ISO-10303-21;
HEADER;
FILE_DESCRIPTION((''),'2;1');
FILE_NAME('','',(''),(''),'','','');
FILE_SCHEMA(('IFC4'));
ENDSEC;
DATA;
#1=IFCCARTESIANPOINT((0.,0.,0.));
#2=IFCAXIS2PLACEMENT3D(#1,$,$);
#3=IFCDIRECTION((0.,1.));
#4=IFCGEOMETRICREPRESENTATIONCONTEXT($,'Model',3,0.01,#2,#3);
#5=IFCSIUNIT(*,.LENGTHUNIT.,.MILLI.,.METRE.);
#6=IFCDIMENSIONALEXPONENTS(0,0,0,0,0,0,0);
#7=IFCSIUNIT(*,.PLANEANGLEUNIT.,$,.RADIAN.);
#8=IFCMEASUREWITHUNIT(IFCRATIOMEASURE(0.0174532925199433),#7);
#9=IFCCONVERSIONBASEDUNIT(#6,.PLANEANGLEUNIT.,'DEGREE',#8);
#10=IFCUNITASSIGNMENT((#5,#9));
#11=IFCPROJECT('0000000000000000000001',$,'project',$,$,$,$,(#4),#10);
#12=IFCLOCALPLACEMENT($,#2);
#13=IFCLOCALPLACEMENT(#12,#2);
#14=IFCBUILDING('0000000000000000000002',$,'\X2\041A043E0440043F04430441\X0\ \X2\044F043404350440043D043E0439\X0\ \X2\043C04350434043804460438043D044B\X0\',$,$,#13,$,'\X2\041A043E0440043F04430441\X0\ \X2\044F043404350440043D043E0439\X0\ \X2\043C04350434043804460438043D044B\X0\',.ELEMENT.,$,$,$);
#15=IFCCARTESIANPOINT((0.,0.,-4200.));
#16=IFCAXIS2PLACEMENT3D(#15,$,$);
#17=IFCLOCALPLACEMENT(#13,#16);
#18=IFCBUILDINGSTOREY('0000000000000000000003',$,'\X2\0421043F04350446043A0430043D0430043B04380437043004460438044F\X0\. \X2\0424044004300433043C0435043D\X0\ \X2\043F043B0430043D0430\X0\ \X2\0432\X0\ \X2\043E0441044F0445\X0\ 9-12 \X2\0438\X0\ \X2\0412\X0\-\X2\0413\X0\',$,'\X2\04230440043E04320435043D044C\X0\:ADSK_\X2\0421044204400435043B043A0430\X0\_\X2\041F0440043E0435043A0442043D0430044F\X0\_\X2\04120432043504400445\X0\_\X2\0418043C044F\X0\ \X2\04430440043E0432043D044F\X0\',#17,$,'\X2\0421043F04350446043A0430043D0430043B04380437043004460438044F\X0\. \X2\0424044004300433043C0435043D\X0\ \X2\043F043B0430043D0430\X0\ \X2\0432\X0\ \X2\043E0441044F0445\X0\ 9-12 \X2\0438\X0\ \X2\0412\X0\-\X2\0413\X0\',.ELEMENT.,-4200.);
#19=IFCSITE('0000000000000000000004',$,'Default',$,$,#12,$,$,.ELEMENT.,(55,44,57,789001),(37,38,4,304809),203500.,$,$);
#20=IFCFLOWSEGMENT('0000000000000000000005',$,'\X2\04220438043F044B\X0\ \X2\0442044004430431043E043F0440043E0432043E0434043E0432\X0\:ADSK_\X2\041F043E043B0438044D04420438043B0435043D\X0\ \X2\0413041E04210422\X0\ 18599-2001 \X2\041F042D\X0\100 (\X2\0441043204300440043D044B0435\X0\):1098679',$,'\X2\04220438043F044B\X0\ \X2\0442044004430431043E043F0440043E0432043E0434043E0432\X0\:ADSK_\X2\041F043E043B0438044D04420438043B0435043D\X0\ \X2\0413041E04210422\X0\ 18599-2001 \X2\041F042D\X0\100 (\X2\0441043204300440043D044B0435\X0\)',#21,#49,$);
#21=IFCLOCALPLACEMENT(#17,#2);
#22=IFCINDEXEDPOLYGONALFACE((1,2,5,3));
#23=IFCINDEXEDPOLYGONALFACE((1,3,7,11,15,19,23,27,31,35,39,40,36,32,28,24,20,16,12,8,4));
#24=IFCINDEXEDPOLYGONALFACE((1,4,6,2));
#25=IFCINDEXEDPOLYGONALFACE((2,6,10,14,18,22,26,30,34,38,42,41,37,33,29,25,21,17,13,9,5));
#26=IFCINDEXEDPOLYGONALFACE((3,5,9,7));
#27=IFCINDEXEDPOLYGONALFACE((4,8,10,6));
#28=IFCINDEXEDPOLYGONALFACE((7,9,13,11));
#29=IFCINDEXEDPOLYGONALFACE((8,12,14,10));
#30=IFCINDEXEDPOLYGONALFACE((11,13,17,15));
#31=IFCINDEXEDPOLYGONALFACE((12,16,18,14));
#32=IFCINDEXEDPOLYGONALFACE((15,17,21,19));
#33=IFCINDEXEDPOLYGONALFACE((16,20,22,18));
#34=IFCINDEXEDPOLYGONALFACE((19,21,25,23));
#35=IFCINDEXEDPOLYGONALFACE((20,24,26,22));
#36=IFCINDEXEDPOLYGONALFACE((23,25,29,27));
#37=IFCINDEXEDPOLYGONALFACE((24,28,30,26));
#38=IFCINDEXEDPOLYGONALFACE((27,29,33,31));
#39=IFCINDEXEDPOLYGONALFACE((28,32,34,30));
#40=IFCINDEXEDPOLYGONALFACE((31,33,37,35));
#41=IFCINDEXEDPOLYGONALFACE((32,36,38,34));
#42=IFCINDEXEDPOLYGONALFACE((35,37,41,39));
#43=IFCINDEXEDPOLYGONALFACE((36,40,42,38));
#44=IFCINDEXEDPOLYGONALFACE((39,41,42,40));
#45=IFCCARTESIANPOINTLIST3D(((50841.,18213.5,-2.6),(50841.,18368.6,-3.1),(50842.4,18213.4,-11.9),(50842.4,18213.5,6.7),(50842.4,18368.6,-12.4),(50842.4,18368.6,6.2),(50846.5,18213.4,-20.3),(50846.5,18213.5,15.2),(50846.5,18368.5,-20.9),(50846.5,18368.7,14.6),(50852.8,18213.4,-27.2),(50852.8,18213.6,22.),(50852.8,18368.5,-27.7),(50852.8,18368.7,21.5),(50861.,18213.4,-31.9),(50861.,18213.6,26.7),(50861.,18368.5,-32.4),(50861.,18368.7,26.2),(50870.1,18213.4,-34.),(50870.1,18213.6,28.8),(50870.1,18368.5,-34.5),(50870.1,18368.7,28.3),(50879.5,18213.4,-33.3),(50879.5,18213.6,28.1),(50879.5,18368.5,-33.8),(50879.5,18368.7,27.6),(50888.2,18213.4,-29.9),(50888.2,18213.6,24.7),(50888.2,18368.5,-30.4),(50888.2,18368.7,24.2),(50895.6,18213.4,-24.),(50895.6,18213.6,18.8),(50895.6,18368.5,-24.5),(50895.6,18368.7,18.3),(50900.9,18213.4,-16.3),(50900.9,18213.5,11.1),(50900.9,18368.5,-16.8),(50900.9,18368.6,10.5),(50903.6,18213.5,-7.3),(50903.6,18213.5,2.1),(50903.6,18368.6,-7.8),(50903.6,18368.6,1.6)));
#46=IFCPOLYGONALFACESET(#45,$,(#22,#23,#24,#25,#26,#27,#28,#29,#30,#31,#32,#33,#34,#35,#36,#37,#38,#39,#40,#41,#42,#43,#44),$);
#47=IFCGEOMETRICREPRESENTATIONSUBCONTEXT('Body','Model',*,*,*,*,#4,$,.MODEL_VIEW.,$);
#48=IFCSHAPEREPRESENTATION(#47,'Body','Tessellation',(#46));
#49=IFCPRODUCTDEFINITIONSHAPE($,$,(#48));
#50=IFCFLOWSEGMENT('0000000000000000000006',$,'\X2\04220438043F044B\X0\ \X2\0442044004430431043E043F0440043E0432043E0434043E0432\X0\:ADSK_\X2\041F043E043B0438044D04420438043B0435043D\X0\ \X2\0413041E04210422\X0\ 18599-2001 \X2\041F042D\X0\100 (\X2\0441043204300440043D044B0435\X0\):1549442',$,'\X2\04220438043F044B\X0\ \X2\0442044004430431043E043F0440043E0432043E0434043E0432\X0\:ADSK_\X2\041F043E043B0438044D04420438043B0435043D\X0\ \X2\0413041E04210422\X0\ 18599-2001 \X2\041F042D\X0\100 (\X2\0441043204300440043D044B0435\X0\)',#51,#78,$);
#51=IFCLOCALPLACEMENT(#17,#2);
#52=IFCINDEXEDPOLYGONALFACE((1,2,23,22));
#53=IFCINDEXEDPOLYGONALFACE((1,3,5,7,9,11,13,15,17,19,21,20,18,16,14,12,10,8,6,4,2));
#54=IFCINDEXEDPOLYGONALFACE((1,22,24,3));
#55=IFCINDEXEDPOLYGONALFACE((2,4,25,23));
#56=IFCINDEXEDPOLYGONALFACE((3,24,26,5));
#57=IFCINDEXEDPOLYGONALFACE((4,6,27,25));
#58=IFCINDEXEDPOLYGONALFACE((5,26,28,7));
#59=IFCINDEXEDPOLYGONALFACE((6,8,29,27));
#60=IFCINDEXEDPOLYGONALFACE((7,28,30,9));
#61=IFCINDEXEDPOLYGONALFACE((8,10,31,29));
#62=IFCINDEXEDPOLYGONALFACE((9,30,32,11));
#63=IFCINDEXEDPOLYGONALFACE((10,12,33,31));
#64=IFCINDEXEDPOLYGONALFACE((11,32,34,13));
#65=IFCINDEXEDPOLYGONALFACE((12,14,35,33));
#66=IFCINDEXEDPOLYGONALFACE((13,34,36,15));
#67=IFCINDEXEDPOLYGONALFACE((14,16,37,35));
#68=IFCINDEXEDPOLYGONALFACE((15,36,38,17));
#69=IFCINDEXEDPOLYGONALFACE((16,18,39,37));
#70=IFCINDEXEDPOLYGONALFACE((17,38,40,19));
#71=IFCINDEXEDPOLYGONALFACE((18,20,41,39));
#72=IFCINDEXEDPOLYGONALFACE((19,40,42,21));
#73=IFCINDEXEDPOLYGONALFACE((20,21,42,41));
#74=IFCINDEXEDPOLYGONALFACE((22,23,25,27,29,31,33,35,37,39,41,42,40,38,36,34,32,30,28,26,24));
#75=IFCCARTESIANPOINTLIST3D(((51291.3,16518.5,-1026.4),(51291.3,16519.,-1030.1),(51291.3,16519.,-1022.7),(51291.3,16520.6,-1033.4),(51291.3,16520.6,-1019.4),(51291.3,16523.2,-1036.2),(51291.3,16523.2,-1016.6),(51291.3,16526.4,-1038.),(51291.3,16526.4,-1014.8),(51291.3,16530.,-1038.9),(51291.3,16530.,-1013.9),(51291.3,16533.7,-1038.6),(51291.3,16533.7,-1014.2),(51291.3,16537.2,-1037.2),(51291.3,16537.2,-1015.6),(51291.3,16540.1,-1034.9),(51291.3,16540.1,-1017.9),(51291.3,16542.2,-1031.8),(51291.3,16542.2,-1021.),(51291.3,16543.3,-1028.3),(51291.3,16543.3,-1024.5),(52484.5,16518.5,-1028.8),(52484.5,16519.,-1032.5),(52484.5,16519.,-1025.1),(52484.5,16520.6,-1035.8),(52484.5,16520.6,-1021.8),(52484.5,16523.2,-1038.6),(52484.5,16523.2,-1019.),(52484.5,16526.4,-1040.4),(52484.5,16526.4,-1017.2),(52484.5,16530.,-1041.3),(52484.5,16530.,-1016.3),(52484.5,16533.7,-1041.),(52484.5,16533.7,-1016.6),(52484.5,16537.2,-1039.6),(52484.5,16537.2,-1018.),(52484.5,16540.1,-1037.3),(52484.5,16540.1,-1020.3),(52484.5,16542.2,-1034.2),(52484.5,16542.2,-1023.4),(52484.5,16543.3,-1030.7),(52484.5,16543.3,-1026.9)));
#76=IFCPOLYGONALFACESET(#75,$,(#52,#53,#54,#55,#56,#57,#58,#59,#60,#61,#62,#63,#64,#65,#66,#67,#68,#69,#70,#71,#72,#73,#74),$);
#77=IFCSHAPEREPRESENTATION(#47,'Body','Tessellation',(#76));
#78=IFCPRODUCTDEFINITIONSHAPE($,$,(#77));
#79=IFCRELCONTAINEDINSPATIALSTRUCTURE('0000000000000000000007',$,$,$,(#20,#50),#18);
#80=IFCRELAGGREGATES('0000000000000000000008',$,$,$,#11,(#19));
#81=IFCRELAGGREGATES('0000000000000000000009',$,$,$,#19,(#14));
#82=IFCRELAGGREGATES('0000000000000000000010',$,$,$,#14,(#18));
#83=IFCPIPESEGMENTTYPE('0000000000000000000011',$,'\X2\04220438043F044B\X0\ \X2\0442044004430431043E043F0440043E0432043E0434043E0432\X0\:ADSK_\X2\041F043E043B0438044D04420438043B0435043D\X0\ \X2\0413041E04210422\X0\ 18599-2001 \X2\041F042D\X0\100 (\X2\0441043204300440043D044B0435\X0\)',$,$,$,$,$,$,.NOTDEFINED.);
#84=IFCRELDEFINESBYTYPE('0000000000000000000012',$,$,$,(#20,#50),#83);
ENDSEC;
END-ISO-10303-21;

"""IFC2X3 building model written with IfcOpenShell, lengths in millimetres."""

from ifc_helpers import new_model, entity, si_unit, converted_unit, direction, frame, frame_2d, origin, place, context, subcontext, project, spatial, circle, extrude, type_object, element, save


model = new_model("IFC2X3")

# Units and contexts
model_context = context("Model", 3, precision=0.01, world=origin(), true_north=direction((0.0, 1.0)))
body_context = subcontext(model_context, "Body", "Model", "MODEL_VIEW")
ifc_project = project(units=[si_unit("LENGTHUNIT", "METRE", prefix="MILLI"), converted_unit("PLANEANGLEUNIT", "DEGREE", entity("IfcRatioMeasure", 0.0174532925199433), si_unit("PLANEANGLEUNIT", "RADIAN"), dimensions=[0, 0, 0, 0, 0, 0, 0])], contexts=[model_context])

# Site, building, storey
site_placement = place(None, frame((0.0, 0.0, 0.0)))
site = spatial("IfcSite", under=ifc_project, at=site_placement, Name="Default", CompositionType="ELEMENT", RefLatitude=(55, 44, 57, 789001), RefLongitude=(37, 38, 4, 304809), RefElevation=203500.0)
building_placement = place(site_placement, origin())
building = spatial("IfcBuilding", under=site, at=building_placement, Name="Корпус ядерной медицины", LongName="Корпус ядерной медицины", CompositionType="ELEMENT")
storey_placement = place(building_placement, frame((0.0, 0.0, -4200.0)))
storey = spatial("IfcBuildingStorey", under=building, at=storey_placement, Name="Спецканализация. Фрагмен плана в осях 9-12 и В-Г", ObjectType="Уровень:ADSK_Стрелка_Проектная_Вверх_Имя уровня", LongName="Спецканализация. Фрагмен плана в осях 9-12 и В-Г", CompositionType="ELEMENT", Elevation=-4200.0)

# Flow segments
pipe_segment_type = type_object("IfcPipeSegmentType", Name="Типы трубопроводов:ADSK_Полиэтилен ГОСТ 18599-2001 ПЭ100 (сварные)", PredefinedType="NOTDEFINED")
flow_segment_1_placement = place(storey_placement, frame((50839.4, 18213.4, -36.2)))
element("IfcFlowSegment", 1, at=flow_segment_1_placement, inside=storey, type_object=pipe_segment_type, Name="Типы трубопроводов:ADSK_Полиэтилен ГОСТ 18599-2001 ПЭ100 (сварные):1098679", ObjectType="Типы трубопроводов:ADSK_Полиэтилен ГОСТ 18599-2001 ПЭ100 (сварные)", context=body_context, shape_type="SweptSolid", body=[
    extrude(circle(Radius=31.5, at=frame_2d((0.0, 0.0), x_axis=(1.0, 0.0))), frame((33.1, 155.2, 33.1), z_axis=(0.0, -0.999994, 0.003467), x_axis=(-1.0, 0.0, 0.0)), (0.0, 0.0, 1.0), 155.1),
])
flow_segment_2_placement = place(storey_placement, frame((51291.3, 16516.9, -1042.9)))
element("IfcFlowSegment", 2, at=flow_segment_2_placement, inside=storey, type_object=pipe_segment_type, Name="Типы трубопроводов:ADSK_Полиэтилен ГОСТ 18599-2001 ПЭ100 (сварные):1549442", ObjectType="Типы трубопроводов:ADSK_Полиэтилен ГОСТ 18599-2001 ПЭ100 (сварные)", context=body_context, shape_type="SweptSolid", body=[
    extrude(circle(Radius=12.5, at=frame_2d((0.0, 0.0), x_axis=(1.0, 0.0))), frame((1193.2, 14.1, 14.1), z_axis=(-0.999998, 0.0, 0.002), x_axis=(0.0, -1.0, 0.0)), (0.0, 0.0, 1.0), 1193.2),
])

save(model, "model.ifc")
